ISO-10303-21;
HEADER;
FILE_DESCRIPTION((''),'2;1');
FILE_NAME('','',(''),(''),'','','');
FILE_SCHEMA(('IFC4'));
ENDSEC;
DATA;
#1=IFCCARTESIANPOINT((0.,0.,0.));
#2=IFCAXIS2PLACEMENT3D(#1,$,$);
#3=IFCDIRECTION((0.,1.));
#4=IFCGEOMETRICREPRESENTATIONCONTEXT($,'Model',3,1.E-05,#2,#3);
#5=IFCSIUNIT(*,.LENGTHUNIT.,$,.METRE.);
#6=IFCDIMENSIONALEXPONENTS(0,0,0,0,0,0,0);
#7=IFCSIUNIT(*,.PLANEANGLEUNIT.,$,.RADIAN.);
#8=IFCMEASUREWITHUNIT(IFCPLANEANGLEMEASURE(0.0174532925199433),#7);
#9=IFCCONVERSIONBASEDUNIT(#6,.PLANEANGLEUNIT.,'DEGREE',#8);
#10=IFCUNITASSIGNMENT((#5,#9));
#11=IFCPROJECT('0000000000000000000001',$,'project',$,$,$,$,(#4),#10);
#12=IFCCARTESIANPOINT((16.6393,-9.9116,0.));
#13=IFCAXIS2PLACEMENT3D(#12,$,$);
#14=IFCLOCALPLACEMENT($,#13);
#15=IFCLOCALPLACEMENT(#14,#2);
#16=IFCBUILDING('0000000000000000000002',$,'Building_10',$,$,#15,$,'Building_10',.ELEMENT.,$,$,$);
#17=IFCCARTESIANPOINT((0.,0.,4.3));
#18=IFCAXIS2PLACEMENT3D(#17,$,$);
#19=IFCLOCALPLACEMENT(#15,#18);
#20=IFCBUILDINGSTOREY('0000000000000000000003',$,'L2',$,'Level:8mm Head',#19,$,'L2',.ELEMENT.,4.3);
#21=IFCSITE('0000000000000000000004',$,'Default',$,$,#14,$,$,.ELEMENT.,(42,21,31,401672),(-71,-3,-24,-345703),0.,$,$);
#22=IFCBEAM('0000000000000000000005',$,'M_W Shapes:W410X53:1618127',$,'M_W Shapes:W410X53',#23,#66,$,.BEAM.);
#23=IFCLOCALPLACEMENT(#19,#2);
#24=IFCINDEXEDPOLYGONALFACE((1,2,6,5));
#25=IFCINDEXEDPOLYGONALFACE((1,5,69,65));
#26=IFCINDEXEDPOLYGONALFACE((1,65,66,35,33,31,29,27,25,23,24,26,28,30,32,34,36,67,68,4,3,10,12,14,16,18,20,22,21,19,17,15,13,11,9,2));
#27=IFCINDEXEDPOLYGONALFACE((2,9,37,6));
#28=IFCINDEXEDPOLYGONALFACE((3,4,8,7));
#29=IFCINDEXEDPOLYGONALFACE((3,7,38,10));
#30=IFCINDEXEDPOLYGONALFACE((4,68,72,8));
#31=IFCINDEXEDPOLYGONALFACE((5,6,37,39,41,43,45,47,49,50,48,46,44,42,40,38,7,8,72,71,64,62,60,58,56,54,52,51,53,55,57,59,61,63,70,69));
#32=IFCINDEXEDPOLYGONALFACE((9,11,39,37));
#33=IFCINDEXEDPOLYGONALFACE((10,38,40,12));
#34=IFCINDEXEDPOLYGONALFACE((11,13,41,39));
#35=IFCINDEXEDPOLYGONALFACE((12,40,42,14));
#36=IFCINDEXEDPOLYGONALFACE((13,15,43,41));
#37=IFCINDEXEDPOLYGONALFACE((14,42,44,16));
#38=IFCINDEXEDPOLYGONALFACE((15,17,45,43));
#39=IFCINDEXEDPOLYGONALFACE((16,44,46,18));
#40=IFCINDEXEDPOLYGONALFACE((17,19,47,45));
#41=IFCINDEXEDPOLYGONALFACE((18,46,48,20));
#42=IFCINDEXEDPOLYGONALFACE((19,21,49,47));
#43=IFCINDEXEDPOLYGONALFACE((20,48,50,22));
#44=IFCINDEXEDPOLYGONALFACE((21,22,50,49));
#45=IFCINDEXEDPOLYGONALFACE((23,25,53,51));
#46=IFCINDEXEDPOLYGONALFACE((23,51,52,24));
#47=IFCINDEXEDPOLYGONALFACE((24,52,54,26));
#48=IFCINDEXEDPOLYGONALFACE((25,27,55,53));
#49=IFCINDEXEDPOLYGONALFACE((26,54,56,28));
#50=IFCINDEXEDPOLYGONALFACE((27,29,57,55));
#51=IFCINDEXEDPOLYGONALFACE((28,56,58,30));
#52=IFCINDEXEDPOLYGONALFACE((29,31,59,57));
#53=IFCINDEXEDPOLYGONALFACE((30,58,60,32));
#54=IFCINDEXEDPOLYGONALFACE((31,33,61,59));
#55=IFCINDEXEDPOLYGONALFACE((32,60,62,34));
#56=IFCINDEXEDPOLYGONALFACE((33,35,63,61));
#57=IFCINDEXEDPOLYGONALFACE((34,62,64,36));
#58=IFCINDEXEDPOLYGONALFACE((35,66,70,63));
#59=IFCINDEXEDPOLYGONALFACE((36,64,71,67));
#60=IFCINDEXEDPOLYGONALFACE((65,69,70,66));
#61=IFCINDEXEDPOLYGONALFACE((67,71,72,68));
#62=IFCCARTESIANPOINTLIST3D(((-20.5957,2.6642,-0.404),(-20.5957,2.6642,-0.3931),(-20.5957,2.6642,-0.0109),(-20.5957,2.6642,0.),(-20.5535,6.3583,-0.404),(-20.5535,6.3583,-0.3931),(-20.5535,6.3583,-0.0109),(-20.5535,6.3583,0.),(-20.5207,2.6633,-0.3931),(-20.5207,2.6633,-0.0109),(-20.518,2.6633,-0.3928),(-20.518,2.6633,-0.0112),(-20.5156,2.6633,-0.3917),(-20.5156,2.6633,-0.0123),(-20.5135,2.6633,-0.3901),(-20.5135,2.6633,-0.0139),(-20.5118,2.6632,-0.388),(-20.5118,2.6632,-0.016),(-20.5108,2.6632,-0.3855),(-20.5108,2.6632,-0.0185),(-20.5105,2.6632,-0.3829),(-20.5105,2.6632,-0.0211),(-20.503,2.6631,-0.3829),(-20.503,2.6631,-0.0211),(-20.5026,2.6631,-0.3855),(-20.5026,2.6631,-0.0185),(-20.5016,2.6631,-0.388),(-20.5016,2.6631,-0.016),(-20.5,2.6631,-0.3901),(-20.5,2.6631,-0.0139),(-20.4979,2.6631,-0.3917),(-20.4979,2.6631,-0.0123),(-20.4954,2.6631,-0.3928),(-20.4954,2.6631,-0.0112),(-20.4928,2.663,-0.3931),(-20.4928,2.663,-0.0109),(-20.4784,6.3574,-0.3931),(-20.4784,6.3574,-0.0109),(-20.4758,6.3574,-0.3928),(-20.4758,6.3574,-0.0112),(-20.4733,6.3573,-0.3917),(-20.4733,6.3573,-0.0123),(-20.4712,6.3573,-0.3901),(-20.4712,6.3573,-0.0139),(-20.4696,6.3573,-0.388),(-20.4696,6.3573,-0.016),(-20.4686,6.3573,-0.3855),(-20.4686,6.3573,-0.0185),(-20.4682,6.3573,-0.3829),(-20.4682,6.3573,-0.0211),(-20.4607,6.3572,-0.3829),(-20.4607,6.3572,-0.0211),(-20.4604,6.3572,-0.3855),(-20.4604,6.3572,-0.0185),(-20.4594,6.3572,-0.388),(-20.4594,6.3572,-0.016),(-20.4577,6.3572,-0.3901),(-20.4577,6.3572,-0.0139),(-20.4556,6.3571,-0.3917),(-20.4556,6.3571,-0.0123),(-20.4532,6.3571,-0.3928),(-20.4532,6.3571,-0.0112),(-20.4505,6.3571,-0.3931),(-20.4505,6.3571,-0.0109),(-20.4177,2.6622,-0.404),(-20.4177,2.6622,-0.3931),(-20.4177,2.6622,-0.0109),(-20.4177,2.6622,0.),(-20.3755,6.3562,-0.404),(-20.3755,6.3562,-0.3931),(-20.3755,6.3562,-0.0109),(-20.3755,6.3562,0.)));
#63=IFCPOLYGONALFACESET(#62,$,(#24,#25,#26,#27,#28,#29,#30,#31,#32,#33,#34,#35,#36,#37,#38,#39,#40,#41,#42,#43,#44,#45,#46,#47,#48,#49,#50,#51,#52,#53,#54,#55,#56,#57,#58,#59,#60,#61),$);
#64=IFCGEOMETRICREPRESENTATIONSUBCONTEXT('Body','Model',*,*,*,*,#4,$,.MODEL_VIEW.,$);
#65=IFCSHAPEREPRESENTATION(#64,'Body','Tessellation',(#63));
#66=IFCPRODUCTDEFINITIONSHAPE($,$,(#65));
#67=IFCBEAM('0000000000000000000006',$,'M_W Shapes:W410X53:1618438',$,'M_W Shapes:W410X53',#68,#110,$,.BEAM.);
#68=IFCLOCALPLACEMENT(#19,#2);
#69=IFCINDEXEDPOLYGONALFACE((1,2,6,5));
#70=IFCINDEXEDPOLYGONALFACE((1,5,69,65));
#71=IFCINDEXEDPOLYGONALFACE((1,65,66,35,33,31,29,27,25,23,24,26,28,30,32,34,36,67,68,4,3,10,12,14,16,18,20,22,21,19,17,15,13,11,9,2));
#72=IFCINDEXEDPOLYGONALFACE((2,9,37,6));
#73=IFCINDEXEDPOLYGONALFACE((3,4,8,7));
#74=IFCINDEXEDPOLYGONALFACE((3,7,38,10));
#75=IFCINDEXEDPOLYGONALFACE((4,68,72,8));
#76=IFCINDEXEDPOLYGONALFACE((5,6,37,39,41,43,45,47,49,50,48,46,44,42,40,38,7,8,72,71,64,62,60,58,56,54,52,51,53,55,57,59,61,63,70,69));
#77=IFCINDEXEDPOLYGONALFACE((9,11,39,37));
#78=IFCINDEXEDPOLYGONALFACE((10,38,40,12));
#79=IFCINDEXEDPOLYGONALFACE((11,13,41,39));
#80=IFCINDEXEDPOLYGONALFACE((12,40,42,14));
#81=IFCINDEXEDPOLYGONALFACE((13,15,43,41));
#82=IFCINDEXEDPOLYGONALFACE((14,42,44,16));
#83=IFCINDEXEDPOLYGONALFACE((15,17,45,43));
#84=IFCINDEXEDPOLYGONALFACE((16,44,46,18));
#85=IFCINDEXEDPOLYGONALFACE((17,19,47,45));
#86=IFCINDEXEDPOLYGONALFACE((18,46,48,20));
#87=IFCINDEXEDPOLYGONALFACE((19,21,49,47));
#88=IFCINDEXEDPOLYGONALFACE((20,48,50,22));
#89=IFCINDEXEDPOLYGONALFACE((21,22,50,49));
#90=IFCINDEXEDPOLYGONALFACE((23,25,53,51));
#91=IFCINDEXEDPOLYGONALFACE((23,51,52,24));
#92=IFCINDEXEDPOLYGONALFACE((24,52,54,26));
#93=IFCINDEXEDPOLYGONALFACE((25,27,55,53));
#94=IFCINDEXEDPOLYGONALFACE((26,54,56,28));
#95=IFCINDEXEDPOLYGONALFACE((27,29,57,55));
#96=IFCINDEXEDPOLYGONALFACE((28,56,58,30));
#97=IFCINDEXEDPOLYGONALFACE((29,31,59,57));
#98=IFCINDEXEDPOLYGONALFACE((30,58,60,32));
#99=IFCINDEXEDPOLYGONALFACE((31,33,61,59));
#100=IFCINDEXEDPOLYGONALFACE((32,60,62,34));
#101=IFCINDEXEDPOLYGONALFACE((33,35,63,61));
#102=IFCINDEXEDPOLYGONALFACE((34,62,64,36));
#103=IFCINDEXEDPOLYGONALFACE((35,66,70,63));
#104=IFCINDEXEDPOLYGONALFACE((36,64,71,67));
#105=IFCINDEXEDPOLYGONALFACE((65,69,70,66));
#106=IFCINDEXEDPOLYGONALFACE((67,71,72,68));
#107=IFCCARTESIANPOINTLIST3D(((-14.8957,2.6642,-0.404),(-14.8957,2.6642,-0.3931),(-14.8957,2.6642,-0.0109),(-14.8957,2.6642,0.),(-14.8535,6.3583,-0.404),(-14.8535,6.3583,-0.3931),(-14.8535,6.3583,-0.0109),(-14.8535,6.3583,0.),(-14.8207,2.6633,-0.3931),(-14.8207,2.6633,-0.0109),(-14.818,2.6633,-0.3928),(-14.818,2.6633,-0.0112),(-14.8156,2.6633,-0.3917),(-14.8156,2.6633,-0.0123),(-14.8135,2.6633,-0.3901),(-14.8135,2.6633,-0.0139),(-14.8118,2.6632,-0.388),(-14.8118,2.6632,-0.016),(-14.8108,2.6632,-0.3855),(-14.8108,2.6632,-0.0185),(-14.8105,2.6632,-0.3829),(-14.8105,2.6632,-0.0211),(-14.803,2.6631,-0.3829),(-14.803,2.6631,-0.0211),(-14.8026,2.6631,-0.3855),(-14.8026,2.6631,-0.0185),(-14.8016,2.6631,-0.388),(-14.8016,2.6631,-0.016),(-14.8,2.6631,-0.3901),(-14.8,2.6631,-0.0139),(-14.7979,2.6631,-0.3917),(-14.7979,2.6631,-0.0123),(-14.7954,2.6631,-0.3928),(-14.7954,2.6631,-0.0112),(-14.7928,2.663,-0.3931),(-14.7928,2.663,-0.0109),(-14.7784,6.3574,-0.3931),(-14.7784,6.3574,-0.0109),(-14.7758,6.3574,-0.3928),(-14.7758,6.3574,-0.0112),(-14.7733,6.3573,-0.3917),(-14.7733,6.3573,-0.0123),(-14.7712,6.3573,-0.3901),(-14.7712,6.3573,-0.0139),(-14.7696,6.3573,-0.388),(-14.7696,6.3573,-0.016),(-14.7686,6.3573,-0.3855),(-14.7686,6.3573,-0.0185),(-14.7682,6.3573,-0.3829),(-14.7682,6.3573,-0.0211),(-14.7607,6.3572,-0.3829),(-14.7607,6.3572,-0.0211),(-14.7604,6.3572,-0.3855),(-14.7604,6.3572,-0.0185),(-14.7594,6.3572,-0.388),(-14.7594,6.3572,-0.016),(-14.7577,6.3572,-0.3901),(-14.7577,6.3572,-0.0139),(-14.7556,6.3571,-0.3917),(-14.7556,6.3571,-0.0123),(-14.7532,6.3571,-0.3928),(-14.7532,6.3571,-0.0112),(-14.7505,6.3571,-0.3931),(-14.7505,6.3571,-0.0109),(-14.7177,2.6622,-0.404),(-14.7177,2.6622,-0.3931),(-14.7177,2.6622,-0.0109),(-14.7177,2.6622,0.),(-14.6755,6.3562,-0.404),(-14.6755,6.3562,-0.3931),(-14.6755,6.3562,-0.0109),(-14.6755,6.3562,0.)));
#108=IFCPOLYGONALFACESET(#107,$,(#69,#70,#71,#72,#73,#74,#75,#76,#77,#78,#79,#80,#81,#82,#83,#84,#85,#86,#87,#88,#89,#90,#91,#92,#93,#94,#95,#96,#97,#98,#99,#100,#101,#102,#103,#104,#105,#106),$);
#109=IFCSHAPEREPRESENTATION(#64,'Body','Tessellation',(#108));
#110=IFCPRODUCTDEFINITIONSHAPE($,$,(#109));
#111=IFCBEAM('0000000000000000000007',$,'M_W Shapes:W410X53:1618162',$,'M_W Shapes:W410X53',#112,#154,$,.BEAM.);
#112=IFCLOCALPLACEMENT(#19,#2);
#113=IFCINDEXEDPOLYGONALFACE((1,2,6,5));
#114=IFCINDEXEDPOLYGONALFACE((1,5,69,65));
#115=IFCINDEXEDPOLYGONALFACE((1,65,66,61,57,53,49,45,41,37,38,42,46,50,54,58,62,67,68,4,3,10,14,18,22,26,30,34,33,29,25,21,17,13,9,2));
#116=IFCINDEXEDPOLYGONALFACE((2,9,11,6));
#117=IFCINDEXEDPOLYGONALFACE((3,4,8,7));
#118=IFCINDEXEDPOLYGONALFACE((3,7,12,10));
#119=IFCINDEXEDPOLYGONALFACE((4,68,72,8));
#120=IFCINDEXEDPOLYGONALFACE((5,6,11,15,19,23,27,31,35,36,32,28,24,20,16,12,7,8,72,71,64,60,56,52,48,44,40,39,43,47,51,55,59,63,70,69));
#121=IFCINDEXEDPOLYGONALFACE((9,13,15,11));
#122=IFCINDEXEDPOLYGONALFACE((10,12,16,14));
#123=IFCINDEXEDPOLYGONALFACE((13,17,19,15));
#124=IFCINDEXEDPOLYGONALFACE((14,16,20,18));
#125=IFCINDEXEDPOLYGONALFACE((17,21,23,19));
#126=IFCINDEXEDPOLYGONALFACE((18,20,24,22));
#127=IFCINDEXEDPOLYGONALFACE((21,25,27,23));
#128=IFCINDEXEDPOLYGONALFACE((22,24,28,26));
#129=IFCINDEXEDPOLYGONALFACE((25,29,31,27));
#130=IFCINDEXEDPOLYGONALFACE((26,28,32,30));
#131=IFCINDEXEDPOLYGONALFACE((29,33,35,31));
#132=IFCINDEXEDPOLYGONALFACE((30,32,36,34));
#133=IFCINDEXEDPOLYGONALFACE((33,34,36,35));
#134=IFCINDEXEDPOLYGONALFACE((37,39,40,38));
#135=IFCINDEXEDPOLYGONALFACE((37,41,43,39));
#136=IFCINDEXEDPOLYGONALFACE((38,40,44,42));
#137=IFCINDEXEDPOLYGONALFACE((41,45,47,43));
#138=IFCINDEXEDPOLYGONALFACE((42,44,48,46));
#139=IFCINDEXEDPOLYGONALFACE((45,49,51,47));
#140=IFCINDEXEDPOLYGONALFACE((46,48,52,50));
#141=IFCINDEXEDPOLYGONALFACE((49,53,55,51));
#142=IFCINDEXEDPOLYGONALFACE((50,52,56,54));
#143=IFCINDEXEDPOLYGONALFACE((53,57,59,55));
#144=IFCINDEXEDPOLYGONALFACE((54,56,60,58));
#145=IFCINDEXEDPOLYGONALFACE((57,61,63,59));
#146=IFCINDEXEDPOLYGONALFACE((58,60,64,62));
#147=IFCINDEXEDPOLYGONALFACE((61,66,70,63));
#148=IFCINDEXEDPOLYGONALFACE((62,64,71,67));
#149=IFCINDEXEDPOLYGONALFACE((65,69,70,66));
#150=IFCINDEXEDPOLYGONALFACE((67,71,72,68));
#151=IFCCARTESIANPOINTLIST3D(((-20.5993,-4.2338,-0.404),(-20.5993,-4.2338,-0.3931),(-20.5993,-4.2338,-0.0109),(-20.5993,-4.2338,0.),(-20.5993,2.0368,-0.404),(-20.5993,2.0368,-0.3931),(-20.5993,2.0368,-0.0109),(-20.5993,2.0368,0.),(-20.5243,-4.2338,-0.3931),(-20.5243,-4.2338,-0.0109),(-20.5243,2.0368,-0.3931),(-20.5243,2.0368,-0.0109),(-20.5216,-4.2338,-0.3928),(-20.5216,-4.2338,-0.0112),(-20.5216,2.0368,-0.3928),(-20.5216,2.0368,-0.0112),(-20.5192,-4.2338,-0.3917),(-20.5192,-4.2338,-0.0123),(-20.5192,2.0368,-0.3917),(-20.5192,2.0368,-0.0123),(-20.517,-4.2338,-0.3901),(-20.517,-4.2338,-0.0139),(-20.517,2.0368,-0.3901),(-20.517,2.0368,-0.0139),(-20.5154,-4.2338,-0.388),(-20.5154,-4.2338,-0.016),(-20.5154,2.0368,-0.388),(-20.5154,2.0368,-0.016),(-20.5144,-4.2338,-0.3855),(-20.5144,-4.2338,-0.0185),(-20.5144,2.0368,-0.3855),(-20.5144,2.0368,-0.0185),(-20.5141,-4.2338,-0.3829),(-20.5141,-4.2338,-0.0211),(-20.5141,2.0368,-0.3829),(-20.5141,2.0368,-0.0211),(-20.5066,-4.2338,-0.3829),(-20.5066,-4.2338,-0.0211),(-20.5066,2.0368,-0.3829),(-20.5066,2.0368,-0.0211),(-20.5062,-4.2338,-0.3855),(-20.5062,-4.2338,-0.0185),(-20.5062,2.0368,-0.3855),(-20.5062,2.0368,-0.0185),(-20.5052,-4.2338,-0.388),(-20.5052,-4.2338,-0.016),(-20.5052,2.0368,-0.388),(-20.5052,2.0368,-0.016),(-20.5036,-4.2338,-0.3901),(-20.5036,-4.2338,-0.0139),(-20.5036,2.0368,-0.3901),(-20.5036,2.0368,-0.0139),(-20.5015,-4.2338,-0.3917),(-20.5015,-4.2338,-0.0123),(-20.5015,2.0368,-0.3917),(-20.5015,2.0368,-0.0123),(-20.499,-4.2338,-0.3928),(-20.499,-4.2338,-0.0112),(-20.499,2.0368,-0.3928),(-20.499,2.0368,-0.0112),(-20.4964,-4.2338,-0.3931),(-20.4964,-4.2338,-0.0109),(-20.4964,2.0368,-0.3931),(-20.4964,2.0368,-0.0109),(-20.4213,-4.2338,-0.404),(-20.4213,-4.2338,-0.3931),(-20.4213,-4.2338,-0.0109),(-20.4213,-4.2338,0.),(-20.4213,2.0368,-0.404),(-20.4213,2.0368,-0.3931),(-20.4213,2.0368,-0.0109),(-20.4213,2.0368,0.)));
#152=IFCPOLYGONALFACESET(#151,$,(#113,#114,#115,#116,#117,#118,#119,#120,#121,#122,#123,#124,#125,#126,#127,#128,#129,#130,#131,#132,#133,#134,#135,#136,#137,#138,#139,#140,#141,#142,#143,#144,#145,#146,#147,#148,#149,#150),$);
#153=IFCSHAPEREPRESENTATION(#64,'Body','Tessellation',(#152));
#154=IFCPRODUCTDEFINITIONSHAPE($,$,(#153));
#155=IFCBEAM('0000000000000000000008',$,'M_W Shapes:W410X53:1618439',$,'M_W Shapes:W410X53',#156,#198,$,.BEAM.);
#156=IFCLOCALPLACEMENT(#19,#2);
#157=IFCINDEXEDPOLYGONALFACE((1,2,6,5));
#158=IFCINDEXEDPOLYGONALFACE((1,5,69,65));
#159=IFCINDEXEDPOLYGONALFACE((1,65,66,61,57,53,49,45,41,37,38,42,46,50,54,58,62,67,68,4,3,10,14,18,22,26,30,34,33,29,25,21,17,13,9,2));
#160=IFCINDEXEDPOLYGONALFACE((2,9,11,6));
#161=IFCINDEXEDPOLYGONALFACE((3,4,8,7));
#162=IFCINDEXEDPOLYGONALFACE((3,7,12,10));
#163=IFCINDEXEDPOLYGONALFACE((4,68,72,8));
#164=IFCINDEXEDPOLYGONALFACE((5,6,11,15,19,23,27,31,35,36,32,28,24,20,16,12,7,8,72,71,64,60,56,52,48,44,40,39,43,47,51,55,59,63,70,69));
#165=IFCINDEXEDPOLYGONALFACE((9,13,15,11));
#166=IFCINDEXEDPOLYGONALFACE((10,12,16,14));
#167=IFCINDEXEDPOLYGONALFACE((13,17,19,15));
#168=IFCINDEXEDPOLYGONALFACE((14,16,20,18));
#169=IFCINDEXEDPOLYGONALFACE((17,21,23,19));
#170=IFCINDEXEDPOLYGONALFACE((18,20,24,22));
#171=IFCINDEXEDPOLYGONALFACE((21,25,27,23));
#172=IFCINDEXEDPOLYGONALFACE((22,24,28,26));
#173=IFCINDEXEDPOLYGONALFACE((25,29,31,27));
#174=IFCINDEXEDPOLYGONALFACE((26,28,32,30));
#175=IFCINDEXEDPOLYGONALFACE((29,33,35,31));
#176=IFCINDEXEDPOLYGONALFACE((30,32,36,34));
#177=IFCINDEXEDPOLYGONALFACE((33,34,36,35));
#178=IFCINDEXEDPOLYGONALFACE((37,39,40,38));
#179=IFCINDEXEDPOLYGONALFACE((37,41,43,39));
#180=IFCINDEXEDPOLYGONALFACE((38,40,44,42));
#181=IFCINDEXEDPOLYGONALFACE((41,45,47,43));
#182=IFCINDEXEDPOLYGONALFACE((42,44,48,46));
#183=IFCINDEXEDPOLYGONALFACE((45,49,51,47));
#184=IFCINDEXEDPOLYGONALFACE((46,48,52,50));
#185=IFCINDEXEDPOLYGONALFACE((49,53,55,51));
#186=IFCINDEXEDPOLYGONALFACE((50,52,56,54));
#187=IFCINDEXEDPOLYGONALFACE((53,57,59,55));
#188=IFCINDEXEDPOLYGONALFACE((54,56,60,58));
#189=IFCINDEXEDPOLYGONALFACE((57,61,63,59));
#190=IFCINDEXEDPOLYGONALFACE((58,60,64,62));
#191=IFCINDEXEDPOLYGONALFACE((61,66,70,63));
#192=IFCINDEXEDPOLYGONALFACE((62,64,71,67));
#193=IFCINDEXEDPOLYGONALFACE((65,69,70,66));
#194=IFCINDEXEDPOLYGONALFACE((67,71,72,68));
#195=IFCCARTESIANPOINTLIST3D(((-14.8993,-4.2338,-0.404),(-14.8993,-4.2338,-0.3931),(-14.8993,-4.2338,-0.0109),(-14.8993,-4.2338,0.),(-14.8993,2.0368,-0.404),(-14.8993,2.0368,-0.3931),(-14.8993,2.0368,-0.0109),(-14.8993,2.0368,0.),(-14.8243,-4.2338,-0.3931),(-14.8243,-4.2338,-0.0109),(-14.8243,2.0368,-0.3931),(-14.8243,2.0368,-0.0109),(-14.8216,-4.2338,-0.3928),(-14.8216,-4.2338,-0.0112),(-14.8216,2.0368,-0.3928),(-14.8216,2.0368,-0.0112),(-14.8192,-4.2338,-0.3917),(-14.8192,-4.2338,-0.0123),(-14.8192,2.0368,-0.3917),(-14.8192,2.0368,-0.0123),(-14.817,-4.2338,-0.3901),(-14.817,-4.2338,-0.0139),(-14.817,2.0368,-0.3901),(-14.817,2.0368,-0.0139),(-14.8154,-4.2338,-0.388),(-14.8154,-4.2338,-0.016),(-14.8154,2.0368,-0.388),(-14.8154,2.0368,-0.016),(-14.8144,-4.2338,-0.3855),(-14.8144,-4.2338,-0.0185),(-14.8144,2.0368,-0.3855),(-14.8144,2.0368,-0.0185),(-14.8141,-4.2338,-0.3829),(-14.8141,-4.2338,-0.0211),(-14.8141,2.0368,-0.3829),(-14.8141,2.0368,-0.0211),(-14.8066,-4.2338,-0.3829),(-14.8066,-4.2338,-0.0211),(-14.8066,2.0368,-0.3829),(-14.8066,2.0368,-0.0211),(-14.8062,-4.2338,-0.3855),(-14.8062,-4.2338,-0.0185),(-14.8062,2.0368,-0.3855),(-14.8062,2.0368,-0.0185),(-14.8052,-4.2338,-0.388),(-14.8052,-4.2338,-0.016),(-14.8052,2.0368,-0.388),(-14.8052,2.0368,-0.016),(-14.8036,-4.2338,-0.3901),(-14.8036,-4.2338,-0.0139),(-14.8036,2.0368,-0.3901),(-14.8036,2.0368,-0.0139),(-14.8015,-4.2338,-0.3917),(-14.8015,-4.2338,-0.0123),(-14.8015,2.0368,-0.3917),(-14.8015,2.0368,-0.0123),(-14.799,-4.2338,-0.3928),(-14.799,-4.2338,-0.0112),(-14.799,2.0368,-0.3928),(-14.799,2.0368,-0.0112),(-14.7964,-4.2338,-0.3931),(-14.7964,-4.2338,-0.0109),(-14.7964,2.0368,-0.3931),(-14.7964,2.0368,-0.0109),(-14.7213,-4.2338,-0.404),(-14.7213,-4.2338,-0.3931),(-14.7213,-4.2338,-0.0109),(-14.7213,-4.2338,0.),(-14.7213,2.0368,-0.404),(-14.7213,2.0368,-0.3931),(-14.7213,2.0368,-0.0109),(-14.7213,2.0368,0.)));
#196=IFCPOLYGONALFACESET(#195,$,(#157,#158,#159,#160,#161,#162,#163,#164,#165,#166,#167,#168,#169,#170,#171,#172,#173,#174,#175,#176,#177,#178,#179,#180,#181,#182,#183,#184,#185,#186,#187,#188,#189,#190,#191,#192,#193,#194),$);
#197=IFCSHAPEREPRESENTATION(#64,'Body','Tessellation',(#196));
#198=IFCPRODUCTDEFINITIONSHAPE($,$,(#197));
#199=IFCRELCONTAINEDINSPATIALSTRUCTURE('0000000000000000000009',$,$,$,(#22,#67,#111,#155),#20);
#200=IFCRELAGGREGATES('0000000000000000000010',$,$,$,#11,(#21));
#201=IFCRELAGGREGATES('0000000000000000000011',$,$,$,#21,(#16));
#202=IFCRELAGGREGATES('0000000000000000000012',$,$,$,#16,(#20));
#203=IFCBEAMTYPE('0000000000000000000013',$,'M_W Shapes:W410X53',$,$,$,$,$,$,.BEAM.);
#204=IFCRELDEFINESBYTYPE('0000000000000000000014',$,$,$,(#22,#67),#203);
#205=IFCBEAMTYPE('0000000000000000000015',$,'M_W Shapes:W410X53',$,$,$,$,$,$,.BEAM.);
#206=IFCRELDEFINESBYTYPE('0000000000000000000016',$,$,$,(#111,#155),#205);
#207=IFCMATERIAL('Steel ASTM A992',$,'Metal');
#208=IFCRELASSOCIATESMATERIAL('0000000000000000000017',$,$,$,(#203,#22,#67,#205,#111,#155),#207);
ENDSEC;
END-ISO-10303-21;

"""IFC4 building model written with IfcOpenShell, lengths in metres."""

from ifc_helpers import new_model, entity, si_unit, converted_unit, direction, frame, origin, place, context, subcontext, project, spatial, line, arc, indexed_curve, outline, extrude, source, transform, mapped, material, type_object, type_shapes, element, save


model = new_model("IFC4")

# Units and contexts
model_context = context("Model", 3, precision=1e-05, world=origin(), true_north=direction((0.0, 1.0)))
body_context = subcontext(model_context, "Body", "Model", "MODEL_VIEW")
ifc_project = project(units=[si_unit("LENGTHUNIT", "METRE"), converted_unit("PLANEANGLEUNIT", "DEGREE", entity("IfcPlaneAngleMeasure", 0.0174532925199433), si_unit("PLANEANGLEUNIT", "RADIAN"), dimensions=[0, 0, 0, 0, 0, 0, 0])], contexts=[model_context])

# Site, building, storey
site_placement = place(None, frame((16.6393, -9.9116, 0.0)))
site = spatial("IfcSite", under=ifc_project, at=site_placement, Name="Default", CompositionType="ELEMENT", RefLatitude=(42, 21, 31, 401672), RefLongitude=(-71, -3, -24, -345703), RefElevation=0.0)
building_placement = place(site_placement, origin())
building = spatial("IfcBuilding", under=site, at=building_placement, Name="Building_10", LongName="Building_10", CompositionType="ELEMENT")
storey_placement = place(building_placement, frame((0.0, 0.0, 4.3)))
storey = spatial("IfcBuildingStorey", under=building, at=storey_placement, Name="L2", ObjectType="Level:8mm Head", LongName="L2", CompositionType="ELEMENT", Elevation=4.3)

# Beams
ifc_material_1 = material(Name="Steel ASTM A992", Category="Metal")
beam_type_1 = type_object("IfcBeamType", Name="M_W Shapes:W410X53", PredefinedType="BEAM", material=ifc_material_1)
shared_shape_1 = source(origin(), body_context, "Body", "SweptSolid", [
    extrude(outline(indexed_curve([(-0.089, -0.1911), (-0.089, -0.202), (0.089, -0.202), (0.089, -0.1911), (0.0139, -0.1911), (0.0067, -0.1881), (0.0037, -0.1809), (0.0037, 0.1809), (0.0067, 0.1881), (0.0139, 0.1911), (0.089, 0.1911), (0.089, 0.202), (-0.089, 0.202), (-0.089, 0.1911), (-0.0139, 0.1911), (-0.0067, 0.1881), (-0.0037, 0.1809), (-0.0037, -0.1809), (-0.0067, -0.1881), (-0.0139, -0.1911)], segments=[line(1, 2, 3, 4, 5), arc(5, 6, 7), line(7, 8), arc(8, 9, 10), line(10, 11, 12, 13, 14, 15), arc(15, 16, 17), line(17, 18), arc(18, 19, 20), line(20, 1)], self_intersect=False)), frame((-1.8221, 0.0, 0.0), z_axis=(-1.0, 0.0, 0.0), x_axis=(0.0, -1.0, 0.0)), (0.0, 0.0, -1.0), 3.6943),
])
type_shapes(beam_type_1, [shared_shape_1])
for number, where, z_axis, x_axis, name in (
    (1, (-20.4853, 4.5352, -0.202), (0.0, 0.0, 1.0), (-0.011437, -0.999935, 0.0), "M_W Shapes:W410X53:1618127"),
    (2, (-14.7853, 4.5352, -0.202), (0.0, 0.0, 1.0), (-0.011437, -0.999935, 0.0), "M_W Shapes:W410X53:1618438"),
):
    element("IfcBeam", number, at=place(storey_placement, frame(where, z_axis=z_axis, x_axis=x_axis)), inside=storey, type_object=beam_type_1, material=ifc_material_1, Name=name, ObjectType="M_W Shapes:W410X53", PredefinedType="BEAM", context=body_context, shape_type="MappedRepresentation", body=[
        mapped(shared_shape_1, transform((0.0, 0.0, 0.0), scale=1.0)),
    ])
beam_type_2 = type_object("IfcBeamType", Name="M_W Shapes:W410X53", PredefinedType="BEAM", material=ifc_material_1)
shared_shape_2 = source(origin(), body_context, "Body", "SweptSolid", [
    extrude(outline(indexed_curve([(-0.089, -0.1911), (-0.089, -0.202), (0.089, -0.202), (0.089, -0.1911), (0.0139, -0.1911), (0.0067, -0.1881), (0.0037, -0.1809), (0.0037, 0.1809), (0.0067, 0.1881), (0.0139, 0.1911), (0.089, 0.1911), (0.089, 0.202), (-0.089, 0.202), (-0.089, 0.1911), (-0.0139, 0.1911), (-0.0067, 0.1881), (-0.0037, 0.1809), (-0.0037, -0.1809), (-0.0067, -0.1881), (-0.0139, -0.1911)], segments=[line(1, 2, 3, 4, 5), arc(5, 6, 7), line(7, 8), arc(8, 9, 10), line(10, 11, 12, 13, 14, 15), arc(15, 16, 17), line(17, 18), arc(18, 19, 20), line(20, 1)], self_intersect=False)), frame((-3.1353, 0.0, 0.0), z_axis=(-1.0, 0.0, 0.0), x_axis=(0.0, -1.0, 0.0)), (0.0, 0.0, -1.0), 6.2706),
])
type_shapes(beam_type_2, [shared_shape_2])
for number, where, z_axis, x_axis, name in (
    (3, (-20.5103, -1.0985, -0.202), (0.0, 0.0, 1.0), (0.0, 1.0, 0.0), "M_W Shapes:W410X53:1618162"),
    (4, (-14.8103, -1.0985, -0.202), (0.0, 0.0, 1.0), (0.0, 1.0, 0.0), "M_W Shapes:W410X53:1618439"),
):
    element("IfcBeam", number, at=place(storey_placement, frame(where, z_axis=z_axis, x_axis=x_axis)), inside=storey, type_object=beam_type_2, material=ifc_material_1, Name=name, ObjectType="M_W Shapes:W410X53", PredefinedType="BEAM", context=body_context, shape_type="MappedRepresentation", body=[
        mapped(shared_shape_2, transform((0.0, 0.0, 0.0), scale=1.0)),
    ])

save(model, "model.ifc")
